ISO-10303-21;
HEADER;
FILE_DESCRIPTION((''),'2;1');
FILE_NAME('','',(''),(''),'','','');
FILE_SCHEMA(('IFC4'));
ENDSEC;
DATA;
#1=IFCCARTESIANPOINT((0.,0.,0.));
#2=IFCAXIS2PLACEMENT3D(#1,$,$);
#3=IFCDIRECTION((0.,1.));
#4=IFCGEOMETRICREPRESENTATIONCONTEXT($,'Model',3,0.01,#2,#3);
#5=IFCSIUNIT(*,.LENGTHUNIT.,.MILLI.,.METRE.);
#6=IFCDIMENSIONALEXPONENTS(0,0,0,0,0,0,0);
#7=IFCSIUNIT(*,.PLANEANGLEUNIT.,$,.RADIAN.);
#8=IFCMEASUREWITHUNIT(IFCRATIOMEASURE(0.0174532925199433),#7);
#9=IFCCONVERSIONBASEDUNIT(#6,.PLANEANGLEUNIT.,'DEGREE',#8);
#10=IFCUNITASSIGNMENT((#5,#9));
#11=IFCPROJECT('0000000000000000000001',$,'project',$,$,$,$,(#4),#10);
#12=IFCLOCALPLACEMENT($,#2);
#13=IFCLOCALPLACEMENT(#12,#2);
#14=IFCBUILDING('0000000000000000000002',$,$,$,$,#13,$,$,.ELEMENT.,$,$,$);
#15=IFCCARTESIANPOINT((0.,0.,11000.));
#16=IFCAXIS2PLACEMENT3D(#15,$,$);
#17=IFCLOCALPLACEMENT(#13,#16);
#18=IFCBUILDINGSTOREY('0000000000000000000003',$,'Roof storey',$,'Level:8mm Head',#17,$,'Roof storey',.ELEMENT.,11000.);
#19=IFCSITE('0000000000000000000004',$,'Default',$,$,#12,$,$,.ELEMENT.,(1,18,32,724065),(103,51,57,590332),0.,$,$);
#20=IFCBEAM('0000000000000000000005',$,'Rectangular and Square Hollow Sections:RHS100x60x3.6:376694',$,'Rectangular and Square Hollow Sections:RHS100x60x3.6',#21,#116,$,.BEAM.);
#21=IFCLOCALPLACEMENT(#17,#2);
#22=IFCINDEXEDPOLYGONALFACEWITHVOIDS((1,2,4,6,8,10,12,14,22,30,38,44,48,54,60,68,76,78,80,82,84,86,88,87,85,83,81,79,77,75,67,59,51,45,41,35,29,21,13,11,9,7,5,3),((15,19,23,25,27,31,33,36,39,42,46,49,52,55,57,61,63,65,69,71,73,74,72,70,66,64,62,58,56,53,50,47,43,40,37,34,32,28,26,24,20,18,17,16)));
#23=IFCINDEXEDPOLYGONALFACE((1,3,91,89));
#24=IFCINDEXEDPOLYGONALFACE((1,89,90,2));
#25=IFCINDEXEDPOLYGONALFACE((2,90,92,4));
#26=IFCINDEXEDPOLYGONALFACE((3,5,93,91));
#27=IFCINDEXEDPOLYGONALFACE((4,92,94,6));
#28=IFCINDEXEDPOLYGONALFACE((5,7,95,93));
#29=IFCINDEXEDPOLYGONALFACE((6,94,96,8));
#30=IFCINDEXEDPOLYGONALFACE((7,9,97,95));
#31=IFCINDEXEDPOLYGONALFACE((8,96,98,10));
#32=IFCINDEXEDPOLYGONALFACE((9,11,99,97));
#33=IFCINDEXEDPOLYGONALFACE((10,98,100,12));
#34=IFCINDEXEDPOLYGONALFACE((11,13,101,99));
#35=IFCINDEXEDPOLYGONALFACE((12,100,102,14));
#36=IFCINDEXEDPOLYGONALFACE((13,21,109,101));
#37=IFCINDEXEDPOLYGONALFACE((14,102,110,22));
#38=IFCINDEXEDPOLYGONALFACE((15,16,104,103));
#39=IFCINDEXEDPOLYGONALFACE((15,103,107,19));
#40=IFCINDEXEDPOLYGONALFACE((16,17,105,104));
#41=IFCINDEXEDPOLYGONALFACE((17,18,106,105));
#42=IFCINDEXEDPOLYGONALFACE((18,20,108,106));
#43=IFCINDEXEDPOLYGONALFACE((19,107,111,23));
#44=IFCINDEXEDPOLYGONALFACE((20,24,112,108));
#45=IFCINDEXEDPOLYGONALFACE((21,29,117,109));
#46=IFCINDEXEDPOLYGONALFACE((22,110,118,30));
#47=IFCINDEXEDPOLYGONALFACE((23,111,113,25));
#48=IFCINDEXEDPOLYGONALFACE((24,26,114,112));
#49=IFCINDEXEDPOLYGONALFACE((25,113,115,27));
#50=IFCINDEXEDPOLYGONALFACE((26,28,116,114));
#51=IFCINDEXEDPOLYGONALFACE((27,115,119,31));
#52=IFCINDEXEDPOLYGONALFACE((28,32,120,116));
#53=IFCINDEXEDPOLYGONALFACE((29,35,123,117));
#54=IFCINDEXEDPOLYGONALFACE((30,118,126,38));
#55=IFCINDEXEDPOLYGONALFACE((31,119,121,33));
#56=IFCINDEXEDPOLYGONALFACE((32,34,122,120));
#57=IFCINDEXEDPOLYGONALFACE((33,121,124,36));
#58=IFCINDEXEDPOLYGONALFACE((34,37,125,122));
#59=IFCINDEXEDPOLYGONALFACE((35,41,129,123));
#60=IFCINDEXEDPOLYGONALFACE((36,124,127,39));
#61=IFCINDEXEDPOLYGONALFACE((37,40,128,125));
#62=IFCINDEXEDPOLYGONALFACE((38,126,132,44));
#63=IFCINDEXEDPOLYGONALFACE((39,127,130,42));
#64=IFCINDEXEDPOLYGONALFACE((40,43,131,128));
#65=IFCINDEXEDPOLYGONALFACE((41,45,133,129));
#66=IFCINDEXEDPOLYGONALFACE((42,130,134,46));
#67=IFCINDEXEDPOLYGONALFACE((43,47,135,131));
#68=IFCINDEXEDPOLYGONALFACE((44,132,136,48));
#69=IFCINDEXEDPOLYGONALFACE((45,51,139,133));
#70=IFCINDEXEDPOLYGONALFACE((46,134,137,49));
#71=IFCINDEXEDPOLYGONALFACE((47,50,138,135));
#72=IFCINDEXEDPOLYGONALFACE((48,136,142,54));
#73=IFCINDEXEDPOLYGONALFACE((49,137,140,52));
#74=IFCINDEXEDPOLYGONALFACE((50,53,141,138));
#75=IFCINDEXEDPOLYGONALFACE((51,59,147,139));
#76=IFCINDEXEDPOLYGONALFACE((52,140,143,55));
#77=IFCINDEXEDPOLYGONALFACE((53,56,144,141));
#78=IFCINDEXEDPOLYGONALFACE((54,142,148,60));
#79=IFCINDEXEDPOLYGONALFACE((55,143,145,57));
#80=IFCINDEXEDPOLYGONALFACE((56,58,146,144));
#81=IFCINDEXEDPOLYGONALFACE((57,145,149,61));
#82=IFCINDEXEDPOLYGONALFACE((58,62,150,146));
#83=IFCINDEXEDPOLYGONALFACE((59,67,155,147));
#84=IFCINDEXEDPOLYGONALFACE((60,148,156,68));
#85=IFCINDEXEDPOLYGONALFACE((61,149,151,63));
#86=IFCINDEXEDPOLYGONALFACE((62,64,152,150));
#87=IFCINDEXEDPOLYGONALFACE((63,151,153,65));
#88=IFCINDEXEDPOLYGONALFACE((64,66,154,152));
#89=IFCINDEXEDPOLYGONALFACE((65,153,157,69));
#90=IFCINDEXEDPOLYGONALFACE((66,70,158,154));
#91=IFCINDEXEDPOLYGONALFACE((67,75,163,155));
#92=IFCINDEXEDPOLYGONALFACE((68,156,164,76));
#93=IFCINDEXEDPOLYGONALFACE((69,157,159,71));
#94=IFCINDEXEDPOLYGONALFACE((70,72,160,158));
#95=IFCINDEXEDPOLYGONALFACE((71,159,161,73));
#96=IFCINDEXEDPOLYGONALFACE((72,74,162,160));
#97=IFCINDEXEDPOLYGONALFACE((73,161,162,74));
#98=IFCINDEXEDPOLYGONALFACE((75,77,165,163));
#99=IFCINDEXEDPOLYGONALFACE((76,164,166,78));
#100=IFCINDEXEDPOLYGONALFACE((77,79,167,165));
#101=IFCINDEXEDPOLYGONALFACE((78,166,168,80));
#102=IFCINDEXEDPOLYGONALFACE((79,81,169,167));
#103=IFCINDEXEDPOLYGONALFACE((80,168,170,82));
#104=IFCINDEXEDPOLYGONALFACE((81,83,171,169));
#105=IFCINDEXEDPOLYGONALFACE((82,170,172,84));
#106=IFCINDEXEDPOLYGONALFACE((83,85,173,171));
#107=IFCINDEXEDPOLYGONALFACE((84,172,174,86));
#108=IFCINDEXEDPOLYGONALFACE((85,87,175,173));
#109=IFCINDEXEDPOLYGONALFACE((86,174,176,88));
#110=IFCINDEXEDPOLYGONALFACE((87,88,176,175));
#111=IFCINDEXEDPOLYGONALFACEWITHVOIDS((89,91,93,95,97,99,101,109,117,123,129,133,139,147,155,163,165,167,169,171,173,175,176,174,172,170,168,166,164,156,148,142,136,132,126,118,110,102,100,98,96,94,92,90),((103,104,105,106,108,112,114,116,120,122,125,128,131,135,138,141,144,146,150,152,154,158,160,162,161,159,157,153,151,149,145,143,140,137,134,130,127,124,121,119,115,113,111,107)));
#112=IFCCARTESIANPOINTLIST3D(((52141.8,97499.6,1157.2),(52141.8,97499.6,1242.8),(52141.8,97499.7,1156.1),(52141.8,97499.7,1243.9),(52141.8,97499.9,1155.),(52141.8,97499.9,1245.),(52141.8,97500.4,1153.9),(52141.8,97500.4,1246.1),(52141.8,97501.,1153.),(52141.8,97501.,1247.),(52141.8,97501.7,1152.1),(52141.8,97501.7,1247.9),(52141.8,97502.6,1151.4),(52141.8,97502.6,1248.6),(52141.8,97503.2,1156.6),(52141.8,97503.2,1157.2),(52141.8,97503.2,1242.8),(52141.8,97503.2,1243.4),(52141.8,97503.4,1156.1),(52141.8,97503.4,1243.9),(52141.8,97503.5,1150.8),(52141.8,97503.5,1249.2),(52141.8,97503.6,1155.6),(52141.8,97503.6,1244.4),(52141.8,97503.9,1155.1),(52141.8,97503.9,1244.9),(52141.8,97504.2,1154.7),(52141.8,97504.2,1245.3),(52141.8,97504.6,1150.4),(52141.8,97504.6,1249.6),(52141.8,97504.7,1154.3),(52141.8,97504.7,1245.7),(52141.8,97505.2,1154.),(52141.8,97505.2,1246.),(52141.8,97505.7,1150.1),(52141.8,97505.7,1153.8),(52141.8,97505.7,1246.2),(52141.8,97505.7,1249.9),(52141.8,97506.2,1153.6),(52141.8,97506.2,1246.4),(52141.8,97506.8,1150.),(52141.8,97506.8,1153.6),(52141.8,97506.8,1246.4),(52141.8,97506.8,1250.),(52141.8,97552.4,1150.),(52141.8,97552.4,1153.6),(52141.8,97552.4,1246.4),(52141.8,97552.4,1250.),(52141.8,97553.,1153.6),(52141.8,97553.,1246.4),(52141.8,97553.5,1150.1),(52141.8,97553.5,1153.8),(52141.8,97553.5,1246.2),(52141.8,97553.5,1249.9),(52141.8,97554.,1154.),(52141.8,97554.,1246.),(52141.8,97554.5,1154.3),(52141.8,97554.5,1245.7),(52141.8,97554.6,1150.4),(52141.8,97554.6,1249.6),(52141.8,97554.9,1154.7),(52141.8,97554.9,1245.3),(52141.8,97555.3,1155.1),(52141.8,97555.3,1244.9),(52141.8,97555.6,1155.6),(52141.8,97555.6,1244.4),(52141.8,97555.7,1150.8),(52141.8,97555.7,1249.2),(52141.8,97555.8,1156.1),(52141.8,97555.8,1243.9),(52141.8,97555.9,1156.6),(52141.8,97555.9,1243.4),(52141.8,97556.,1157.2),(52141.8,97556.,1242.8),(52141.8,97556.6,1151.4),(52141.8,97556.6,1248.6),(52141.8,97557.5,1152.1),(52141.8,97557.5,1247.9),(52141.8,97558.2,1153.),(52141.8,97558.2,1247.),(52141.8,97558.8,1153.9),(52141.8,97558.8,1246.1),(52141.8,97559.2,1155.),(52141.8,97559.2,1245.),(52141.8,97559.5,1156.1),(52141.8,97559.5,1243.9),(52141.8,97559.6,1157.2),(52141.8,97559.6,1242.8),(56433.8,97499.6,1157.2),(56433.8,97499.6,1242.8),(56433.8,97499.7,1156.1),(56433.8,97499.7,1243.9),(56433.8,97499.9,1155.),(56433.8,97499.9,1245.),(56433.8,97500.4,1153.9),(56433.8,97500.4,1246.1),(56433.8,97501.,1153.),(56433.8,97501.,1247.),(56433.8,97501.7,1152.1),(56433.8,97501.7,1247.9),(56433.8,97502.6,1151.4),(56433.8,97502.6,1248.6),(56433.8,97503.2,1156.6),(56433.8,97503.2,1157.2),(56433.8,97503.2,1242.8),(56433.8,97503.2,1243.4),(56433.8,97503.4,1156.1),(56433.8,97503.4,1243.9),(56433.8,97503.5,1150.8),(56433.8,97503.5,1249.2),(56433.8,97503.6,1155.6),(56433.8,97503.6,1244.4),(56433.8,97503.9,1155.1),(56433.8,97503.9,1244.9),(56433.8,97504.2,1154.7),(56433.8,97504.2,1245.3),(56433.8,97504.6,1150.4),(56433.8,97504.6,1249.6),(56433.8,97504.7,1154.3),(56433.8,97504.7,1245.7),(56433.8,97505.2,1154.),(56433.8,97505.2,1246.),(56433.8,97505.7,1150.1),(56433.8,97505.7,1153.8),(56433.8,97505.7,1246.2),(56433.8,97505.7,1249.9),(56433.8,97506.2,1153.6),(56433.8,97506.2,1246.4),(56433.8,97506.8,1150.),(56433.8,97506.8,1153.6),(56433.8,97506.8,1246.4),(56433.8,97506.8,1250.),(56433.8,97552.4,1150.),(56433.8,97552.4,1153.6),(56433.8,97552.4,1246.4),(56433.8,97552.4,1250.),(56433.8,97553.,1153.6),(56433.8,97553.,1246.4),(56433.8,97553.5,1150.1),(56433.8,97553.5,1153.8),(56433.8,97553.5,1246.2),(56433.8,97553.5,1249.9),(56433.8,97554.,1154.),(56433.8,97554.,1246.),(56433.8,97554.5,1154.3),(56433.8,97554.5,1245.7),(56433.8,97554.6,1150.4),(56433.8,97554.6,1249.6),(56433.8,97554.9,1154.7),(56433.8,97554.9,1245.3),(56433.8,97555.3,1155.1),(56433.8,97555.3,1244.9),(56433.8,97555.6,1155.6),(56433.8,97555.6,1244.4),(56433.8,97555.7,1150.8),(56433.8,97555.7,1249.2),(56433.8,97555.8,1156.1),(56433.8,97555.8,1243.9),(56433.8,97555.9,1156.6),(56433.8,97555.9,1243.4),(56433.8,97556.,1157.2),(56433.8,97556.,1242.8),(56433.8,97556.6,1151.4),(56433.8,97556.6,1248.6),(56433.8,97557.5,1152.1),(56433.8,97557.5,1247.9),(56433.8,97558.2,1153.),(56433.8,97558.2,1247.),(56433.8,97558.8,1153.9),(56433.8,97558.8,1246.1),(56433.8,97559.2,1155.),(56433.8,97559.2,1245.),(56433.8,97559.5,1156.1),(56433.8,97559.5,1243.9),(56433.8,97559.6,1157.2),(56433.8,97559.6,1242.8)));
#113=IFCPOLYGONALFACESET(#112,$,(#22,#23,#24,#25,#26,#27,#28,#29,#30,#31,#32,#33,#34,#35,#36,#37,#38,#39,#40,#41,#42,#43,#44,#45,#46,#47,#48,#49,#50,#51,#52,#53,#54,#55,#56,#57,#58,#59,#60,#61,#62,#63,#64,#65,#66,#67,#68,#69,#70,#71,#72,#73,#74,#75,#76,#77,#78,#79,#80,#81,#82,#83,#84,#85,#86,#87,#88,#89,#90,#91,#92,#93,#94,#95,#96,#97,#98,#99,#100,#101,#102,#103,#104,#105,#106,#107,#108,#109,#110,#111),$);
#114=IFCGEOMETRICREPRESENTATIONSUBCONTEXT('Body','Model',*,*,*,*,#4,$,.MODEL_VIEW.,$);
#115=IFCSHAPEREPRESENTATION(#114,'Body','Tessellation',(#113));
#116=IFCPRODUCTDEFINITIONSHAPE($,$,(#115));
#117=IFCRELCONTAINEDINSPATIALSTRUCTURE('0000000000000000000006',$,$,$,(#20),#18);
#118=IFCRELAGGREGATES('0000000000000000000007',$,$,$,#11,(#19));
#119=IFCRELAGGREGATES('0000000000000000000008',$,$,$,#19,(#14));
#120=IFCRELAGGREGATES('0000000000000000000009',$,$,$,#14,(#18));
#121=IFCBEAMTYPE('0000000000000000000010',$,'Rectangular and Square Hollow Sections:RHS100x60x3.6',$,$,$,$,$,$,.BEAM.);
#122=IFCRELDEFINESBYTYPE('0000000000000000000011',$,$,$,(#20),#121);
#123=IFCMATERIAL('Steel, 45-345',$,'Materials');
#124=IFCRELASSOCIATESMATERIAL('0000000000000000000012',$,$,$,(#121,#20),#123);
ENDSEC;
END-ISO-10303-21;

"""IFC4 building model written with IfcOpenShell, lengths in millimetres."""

from ifc_helpers import new_model, entity, si_unit, converted_unit, direction, frame, origin, place, context, subcontext, project, spatial, indexed_curve, outline, extrude, source, transform, mapped, material, type_object, type_shapes, element, save


model = new_model("IFC4")

# Units and contexts
model_context = context("Model", 3, precision=0.01, world=origin(), true_north=direction((0.0, 1.0)))
body_context = subcontext(model_context, "Body", "Model", "MODEL_VIEW")
ifc_project = project(units=[si_unit("LENGTHUNIT", "METRE", prefix="MILLI"), converted_unit("PLANEANGLEUNIT", "DEGREE", entity("IfcRatioMeasure", 0.0174532925199433), si_unit("PLANEANGLEUNIT", "RADIAN"), dimensions=[0, 0, 0, 0, 0, 0, 0])], contexts=[model_context])

# Site, building, storey
site_placement = place(None, origin())
site = spatial("IfcSite", under=ifc_project, at=site_placement, Name="Default", CompositionType="ELEMENT", RefLatitude=(1, 18, 32, 724065), RefLongitude=(103, 51, 57, 590332), RefElevation=0.0)
building_placement = place(site_placement, origin())
building = spatial("IfcBuilding", under=site, at=building_placement, CompositionType="ELEMENT")
storey_placement = place(building_placement, frame((0.0, 0.0, 11000.0)))
storey = spatial("IfcBuildingStorey", under=building, at=storey_placement, Name="Roof storey", ObjectType="Level:8mm Head", LongName="Roof storey", CompositionType="ELEMENT", Elevation=11000.0)

# Shared definitions
ifc_material = material(Name="Steel, 45-345", Category="Materials")

# Beam
beam_type_1 = type_object("IfcBeamType", Name="Rectangular and Square Hollow Sections:RHS100x60x3.6", PredefinedType="BEAM", material=ifc_material)
shared_shape_1 = source(origin(), body_context, "Body", "SweptSolid", [
    extrude(outline(indexed_curve([(-30.0, -42.8), (-29.9, -43.9), (-29.6, -45.0), (-29.2, -46.1), (-28.6, -47.0), (-27.9, -47.9), (-27.0, -48.6), (-26.1, -49.2), (-25.0, -49.6), (-23.9, -49.9), (-22.8, -50.0), (22.8, -50.0), (23.9, -49.9), (25.0, -49.6), (26.1, -49.2), (27.0, -48.6), (27.9, -47.9), (28.6, -47.0), (29.2, -46.1), (29.6, -45.0), (29.9, -43.9), (30.0, -42.8), (30.0, 42.8), (29.9, 43.9), (29.6, 45.0), (29.2, 46.1), (28.6, 47.0), (27.9, 47.9), (27.0, 48.6), (26.1, 49.2), (25.0, 49.6), (23.9, 49.9), (22.8, 50.0), (-22.8, 50.0), (-23.9, 49.9), (-25.0, 49.6), (-26.1, 49.2), (-27.0, 48.6), (-27.9, 47.9), (-28.6, 47.0), (-29.2, 46.1), (-29.6, 45.0), (-29.9, 43.9), (-30.0, 42.8), (-30.0, -42.8)], self_intersect=False), holes=[indexed_curve([(22.8, -46.4), (-22.8, -46.4), (-23.4, -46.4), (-23.9, -46.2), (-24.4, -46.0), (-24.9, -45.7), (-25.3, -45.3), (-25.7, -44.9), (-26.0, -44.4), (-26.2, -43.9), (-26.4, -43.4), (-26.4, -42.8), (-26.4, 42.8), (-26.4, 43.4), (-26.2, 43.9), (-26.0, 44.4), (-25.7, 44.9), (-25.3, 45.3), (-24.9, 45.7), (-24.4, 46.0), (-23.9, 46.2), (-23.4, 46.4), (-22.8, 46.4), (22.8, 46.4), (23.4, 46.4), (23.9, 46.2), (24.4, 46.0), (24.9, 45.7), (25.3, 45.3), (25.7, 44.9), (26.0, 44.4), (26.2, 43.9), (26.4, 43.4), (26.4, 42.8), (26.4, -42.8), (26.4, -43.4), (26.2, -43.9), (26.0, -44.4), (25.7, -44.9), (25.3, -45.3), (24.9, -45.7), (24.4, -46.0), (23.9, -46.2), (23.4, -46.4), (22.8, -46.4)], self_intersect=False)]), frame((-2152.5, 0.0, 0.0), z_axis=(1.0, 0.0, 0.0), x_axis=(0.0, -1.0, 0.0)), (0.0, 0.0, 1.0), 4292.0),
])
type_shapes(beam_type_1, [shared_shape_1])
for number, where, name in (
    (1, (54294.3, 97529.6, 1200.0), "Rectangular and Square Hollow Sections:RHS100x60x3.6:376694"),
):
    element("IfcBeam", number, at=place(storey_placement, frame(where)), inside=storey, type_object=beam_type_1, material=ifc_material, Name=name, ObjectType="Rectangular and Square Hollow Sections:RHS100x60x3.6", PredefinedType="BEAM", context=body_context, shape_type="MappedRepresentation", body=[
        mapped(shared_shape_1, transform((0.0, 0.0, 0.0), scale=1.0)),
    ])

save(model, "model.ifc")
